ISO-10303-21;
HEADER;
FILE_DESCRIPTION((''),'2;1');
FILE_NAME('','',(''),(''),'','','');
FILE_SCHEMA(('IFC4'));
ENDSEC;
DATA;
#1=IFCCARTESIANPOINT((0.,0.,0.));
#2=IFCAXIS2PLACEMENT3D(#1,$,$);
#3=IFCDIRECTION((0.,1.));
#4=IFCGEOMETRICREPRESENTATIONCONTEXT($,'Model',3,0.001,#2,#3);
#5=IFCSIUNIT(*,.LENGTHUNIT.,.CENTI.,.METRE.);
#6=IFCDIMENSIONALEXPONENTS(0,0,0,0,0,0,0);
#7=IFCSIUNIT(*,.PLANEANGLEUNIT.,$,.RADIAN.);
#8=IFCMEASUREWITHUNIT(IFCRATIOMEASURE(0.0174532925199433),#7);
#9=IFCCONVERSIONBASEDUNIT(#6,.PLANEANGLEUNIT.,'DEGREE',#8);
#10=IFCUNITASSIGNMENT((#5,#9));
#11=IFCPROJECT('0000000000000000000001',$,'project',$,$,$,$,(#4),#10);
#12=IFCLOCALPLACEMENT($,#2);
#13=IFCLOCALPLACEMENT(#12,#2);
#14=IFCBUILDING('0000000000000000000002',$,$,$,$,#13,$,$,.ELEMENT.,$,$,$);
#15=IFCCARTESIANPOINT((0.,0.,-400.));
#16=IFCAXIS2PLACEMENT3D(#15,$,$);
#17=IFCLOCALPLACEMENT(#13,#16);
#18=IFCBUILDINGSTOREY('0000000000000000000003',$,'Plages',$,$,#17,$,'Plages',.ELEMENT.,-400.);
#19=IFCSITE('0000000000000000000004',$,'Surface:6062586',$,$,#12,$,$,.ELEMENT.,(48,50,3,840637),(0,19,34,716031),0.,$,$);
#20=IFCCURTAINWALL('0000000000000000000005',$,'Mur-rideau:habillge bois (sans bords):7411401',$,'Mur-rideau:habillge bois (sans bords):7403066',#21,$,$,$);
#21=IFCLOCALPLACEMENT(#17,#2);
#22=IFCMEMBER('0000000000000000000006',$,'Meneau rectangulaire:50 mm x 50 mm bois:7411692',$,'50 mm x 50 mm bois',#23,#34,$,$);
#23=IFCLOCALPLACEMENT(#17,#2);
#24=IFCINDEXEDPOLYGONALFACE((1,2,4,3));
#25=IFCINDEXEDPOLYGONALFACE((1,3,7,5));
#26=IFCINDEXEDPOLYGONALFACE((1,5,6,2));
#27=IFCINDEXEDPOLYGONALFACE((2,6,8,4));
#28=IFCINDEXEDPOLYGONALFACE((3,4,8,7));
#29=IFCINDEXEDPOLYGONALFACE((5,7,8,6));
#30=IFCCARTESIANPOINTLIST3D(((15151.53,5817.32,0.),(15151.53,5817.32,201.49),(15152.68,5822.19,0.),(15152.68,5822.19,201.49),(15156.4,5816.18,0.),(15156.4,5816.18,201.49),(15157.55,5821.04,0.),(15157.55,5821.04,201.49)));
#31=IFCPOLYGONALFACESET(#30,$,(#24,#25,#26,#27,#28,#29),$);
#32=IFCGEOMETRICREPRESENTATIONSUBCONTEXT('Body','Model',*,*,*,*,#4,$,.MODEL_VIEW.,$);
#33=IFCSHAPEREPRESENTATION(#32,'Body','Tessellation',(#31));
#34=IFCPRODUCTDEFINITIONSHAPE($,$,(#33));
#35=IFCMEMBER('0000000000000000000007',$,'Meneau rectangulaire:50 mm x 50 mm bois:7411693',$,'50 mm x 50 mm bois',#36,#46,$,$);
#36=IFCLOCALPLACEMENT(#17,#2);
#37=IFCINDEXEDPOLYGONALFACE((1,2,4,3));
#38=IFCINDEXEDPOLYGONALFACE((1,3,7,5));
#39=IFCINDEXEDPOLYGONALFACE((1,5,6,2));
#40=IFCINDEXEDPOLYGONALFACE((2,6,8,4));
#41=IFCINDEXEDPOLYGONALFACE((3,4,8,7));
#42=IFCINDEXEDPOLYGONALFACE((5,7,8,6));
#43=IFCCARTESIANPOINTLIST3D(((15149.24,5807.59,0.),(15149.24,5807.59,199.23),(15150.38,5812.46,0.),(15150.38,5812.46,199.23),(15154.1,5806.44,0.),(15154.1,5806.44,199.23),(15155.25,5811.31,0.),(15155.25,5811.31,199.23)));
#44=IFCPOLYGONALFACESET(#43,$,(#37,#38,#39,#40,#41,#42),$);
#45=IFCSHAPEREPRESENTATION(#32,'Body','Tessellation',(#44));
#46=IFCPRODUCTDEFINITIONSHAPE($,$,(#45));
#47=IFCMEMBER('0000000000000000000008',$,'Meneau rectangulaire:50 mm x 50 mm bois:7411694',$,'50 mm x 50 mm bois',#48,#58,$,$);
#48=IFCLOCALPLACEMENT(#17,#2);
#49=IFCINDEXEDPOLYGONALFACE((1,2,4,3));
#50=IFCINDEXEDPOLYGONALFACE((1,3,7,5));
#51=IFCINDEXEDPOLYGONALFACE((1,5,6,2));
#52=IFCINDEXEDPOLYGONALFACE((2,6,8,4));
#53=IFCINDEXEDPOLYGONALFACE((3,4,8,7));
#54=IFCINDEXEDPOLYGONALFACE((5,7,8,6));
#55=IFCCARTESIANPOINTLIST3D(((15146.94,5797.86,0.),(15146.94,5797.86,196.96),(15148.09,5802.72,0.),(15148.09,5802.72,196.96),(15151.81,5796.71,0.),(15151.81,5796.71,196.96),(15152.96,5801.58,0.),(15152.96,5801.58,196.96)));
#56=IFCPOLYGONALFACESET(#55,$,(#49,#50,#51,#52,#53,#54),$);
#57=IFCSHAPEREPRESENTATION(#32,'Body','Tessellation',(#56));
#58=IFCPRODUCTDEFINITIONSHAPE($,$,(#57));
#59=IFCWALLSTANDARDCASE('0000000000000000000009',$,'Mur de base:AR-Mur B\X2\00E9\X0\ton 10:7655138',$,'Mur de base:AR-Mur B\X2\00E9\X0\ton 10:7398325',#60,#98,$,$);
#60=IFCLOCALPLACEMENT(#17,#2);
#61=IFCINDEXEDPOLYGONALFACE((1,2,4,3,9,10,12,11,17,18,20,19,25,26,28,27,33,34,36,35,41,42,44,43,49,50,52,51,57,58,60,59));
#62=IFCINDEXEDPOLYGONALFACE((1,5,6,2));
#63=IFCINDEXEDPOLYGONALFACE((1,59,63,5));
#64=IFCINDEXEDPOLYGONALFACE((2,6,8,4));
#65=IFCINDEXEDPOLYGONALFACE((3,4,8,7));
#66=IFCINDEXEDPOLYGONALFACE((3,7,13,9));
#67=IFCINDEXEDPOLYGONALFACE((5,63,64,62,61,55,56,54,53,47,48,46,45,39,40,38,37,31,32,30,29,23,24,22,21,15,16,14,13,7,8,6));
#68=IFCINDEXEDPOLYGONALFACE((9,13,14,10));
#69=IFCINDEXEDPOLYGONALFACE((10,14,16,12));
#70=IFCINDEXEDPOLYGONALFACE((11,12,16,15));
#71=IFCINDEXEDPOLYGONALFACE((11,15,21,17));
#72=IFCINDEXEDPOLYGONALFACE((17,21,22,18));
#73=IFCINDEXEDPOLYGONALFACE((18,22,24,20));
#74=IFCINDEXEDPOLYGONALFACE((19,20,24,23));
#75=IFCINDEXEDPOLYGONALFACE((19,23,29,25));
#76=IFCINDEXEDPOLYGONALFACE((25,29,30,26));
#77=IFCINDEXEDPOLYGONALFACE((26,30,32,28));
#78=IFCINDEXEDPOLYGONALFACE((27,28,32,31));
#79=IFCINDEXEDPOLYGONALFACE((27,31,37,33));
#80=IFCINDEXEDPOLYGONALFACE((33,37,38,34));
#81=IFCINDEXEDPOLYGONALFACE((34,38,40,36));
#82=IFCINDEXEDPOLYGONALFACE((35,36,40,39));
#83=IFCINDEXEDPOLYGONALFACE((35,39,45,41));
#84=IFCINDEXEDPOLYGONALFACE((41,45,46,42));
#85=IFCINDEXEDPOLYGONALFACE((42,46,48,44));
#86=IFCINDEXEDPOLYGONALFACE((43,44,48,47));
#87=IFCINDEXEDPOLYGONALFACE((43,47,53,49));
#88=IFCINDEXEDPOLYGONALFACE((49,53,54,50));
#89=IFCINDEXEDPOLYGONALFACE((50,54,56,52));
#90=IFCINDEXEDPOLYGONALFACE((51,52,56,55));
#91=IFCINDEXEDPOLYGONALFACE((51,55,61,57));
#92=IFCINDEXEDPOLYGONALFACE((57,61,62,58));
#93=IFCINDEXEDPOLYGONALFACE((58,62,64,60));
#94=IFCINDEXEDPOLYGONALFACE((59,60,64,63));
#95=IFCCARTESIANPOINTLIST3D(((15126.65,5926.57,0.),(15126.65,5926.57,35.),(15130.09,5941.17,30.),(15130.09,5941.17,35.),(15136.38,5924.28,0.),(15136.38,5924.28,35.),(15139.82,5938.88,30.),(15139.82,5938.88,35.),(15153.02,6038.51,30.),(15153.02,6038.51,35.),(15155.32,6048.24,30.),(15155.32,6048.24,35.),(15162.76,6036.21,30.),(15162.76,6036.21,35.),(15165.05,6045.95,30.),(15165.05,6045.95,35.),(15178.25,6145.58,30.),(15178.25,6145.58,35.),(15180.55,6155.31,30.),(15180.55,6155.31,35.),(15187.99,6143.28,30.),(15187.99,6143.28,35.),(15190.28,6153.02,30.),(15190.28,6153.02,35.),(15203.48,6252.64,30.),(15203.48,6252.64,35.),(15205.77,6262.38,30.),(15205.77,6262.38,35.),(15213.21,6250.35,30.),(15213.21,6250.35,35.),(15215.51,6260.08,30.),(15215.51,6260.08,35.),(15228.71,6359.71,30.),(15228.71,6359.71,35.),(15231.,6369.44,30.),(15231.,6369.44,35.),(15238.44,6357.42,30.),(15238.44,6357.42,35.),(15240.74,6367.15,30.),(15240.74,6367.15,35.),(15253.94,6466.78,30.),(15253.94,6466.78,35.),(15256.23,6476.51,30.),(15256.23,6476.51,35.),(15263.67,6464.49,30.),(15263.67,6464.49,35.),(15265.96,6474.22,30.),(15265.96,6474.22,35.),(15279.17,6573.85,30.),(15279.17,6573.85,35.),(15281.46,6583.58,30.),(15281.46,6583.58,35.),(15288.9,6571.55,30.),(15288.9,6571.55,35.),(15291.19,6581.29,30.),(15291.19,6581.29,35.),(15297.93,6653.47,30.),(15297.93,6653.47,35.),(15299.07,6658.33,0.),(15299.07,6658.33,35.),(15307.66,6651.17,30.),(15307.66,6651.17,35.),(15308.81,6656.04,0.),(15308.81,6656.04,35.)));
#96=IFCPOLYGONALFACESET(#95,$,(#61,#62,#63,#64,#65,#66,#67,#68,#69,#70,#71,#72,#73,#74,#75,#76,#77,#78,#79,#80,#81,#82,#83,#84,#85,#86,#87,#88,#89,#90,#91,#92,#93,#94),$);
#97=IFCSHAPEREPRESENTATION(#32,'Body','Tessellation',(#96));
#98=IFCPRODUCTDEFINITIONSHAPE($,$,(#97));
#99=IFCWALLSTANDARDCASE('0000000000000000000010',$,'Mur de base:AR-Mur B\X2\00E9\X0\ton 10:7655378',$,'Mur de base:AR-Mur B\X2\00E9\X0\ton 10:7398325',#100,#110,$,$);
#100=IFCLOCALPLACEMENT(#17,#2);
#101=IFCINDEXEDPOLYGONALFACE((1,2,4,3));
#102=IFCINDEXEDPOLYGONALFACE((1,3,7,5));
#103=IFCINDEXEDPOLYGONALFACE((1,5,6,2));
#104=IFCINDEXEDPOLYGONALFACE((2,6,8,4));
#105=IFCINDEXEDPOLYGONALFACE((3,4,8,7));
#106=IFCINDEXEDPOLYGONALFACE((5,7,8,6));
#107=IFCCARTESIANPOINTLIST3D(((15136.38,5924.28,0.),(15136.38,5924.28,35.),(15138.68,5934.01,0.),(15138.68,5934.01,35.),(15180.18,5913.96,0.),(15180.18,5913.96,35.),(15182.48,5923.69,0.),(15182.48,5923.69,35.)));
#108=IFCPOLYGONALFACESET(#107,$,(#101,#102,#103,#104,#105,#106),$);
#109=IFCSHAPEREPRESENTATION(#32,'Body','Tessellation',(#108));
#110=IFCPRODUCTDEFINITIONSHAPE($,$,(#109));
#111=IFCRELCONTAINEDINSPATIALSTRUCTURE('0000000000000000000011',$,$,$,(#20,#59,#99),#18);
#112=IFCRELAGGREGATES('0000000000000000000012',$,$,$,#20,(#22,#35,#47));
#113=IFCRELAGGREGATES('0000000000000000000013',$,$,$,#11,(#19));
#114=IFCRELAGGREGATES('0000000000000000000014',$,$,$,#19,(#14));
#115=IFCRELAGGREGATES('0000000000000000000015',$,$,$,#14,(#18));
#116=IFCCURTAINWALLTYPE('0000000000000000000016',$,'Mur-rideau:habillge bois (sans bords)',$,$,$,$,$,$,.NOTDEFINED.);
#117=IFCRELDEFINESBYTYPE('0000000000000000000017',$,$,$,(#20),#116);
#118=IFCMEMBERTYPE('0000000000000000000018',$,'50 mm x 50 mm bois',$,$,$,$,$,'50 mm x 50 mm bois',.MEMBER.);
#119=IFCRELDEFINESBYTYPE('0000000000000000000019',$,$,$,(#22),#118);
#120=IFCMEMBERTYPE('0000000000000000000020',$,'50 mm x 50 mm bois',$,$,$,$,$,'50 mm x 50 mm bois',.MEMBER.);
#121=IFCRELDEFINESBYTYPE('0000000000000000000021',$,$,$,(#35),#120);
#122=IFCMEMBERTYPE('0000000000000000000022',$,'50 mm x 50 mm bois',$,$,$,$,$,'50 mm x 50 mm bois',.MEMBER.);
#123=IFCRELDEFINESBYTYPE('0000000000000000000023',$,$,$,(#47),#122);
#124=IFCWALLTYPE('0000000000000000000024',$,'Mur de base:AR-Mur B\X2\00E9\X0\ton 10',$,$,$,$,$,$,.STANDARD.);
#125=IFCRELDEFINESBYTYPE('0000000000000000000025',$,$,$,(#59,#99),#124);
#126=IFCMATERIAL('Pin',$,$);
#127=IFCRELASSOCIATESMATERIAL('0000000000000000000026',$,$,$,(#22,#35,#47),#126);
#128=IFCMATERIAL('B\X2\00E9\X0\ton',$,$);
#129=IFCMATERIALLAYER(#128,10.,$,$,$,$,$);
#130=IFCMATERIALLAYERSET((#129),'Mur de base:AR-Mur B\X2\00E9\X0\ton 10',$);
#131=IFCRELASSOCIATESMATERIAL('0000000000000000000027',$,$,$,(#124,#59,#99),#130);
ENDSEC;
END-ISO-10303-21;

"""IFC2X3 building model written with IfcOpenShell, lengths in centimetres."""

from ifc_helpers import new_model, entity, si_unit, converted_unit, direction, frame, frame_2d, origin, origin_2d_with_axis, place, context, subcontext, project, spatial, rectangle, extrude, source, transform, mapped, material, layer, layer_set, layer_usage, type_object, type_shapes, element, aggregate, save


model = new_model("IFC2X3")

# Units and contexts
model_context = context("Model", 3, precision=0.001, world=origin(), true_north=direction((0.0, 1.0)))
body_context = subcontext(model_context, "Body", "Model", "MODEL_VIEW")
ifc_project = project(units=[si_unit("LENGTHUNIT", "METRE", prefix="CENTI"), converted_unit("PLANEANGLEUNIT", "DEGREE", entity("IfcRatioMeasure", 0.0174532925199433), si_unit("PLANEANGLEUNIT", "RADIAN"), dimensions=[0, 0, 0, 0, 0, 0, 0])], contexts=[model_context])

# Site, building, storey
site_placement = place(None, origin())
site = spatial("IfcSite", under=ifc_project, at=site_placement, Name="Surface:6062586", CompositionType="ELEMENT", RefLatitude=(48, 50, 3, 840637), RefLongitude=(0, 19, 34, 716031), RefElevation=0.0)
building_placement = place(site_placement, origin())
building = spatial("IfcBuilding", under=site, at=building_placement, CompositionType="ELEMENT")
storey_placement = place(building_placement, frame((0.0, 0.0, -400.0)))
storey = spatial("IfcBuildingStorey", under=building, at=storey_placement, Name="Plages", LongName="Plages", CompositionType="ELEMENT", Elevation=-400.0)

# Curtain wall, members
curtain_wall_type = type_object("IfcCurtainWallType", Name="Mur-rideau:habillge bois (sans bords)", PredefinedType="NOTDEFINED")
curtain_wall_placement = place(storey_placement, frame((0.0, 0.0, 400.0)))
curtain_wall = element("IfcCurtainWall", 1, at=curtain_wall_placement, inside=storey, type_object=curtain_wall_type, Name="Mur-rideau:habillge bois (sans bords):7411401", ObjectType="Mur-rideau:habillge bois (sans bords):7403066")
ifc_material_1 = material(Name="Pin")
member_type_1 = type_object("IfcMemberType", Name="50 mm x 50 mm bois", ElementType="50 mm x 50 mm bois", PredefinedType="MEMBER")
shared_shape_1 = source(origin(), body_context, "Body", "SweptSolid", [
    extrude(rectangle(XDim=5.0, YDim=5.0, at=origin_2d_with_axis()), frame((0.0, 0.0, -201.49), z_axis=(0.0, 0.0, 1.0), x_axis=(0.0, -1.0, 0.0)), (0.0, 0.0, 1.0), 201.49),
])
type_shapes(member_type_1, [shared_shape_1])
member_1_placement = place(storey_placement, frame((15154.54, 5819.18, 0.0), z_axis=(0.0, 0.0, -1.0), x_axis=(-0.229349, -0.973344, 0.0)))
member_1 = element("IfcMember", 2, at=member_1_placement, type_object=member_type_1, material=ifc_material_1, Name="Meneau rectangulaire:50 mm x 50 mm bois:7411692", ObjectType="50 mm x 50 mm bois", context=body_context, shape_type="MappedRepresentation", body=[
    mapped(shared_shape_1, transform((0.0, 0.0, 0.0), scale=1.0)),
])
member_type_2 = type_object("IfcMemberType", Name="50 mm x 50 mm bois", ElementType="50 mm x 50 mm bois", PredefinedType="MEMBER")
shared_shape_2 = source(origin(), body_context, "Body", "SweptSolid", [
    extrude(rectangle(XDim=5.0, YDim=5.0, at=origin_2d_with_axis()), frame((0.0, 0.0, -199.23), z_axis=(0.0, 0.0, 1.0), x_axis=(0.0, -1.0, 0.0)), (0.0, 0.0, 1.0), 199.23),
])
type_shapes(member_type_2, [shared_shape_2])
member_2_placement = place(storey_placement, frame((15152.24, 5809.45, 0.0), z_axis=(0.0, 0.0, -1.0), x_axis=(-0.229349, -0.973344, 0.0)))
member_2 = element("IfcMember", 3, at=member_2_placement, type_object=member_type_2, material=ifc_material_1, Name="Meneau rectangulaire:50 mm x 50 mm bois:7411693", ObjectType="50 mm x 50 mm bois", context=body_context, shape_type="MappedRepresentation", body=[
    mapped(shared_shape_2, transform((0.0, 0.0, 0.0), scale=1.0)),
])
member_type_3 = type_object("IfcMemberType", Name="50 mm x 50 mm bois", ElementType="50 mm x 50 mm bois", PredefinedType="MEMBER")
shared_shape_3 = source(origin(), body_context, "Body", "SweptSolid", [
    extrude(rectangle(XDim=5.0, YDim=5.0, at=origin_2d_with_axis()), frame((0.0, 0.0, -196.96), z_axis=(0.0, 0.0, 1.0), x_axis=(0.0, -1.0, 0.0)), (0.0, 0.0, 1.0), 196.96),
])
type_shapes(member_type_3, [shared_shape_3])
member_3_placement = place(storey_placement, frame((15149.95, 5799.72, 0.0), z_axis=(0.0, 0.0, -1.0), x_axis=(-0.229349, -0.973344, 0.0)))
member_3 = element("IfcMember", 4, at=member_3_placement, type_object=member_type_3, material=ifc_material_1, Name="Meneau rectangulaire:50 mm x 50 mm bois:7411694", ObjectType="50 mm x 50 mm bois", context=body_context, shape_type="MappedRepresentation", body=[
    mapped(shared_shape_3, transform((0.0, 0.0, 0.0), scale=1.0)),
])
aggregate(curtain_wall, [member_1, member_2, member_3])

# Wall, openings
ifc_material_2 = material(Name="Béton")
ifc_layer = layer(ifc_material_2, 10.0)
ifc_layer_set = layer_set([ifc_layer], Name="Mur de base:AR-Mur Béton 10")
ifc_layer_usage_1 = layer_usage(ifc_layer_set, "AXIS2", "NEGATIVE", 5.0)
wall_type = type_object("IfcWallType", Name="Mur de base:AR-Mur Béton 10", PredefinedType="STANDARD", material=ifc_layer_set)
wall_1_placement = place(storey_placement, frame((15131.52, 5925.43, 0.0), z_axis=(0.0, 0.0, 1.0), x_axis=(0.229349, 0.973344, 0.0)))
wall_1 = element("IfcWallStandardCase", 5, at=wall_1_placement, inside=storey, type_object=wall_type, material=ifc_layer_usage_1, Name="Mur de base:AR-Mur Béton 10:7655138", ObjectType="Mur de base:AR-Mur Béton 10:7398325", context=body_context, shape_type="SweptSolid", body=[
    extrude(rectangle(XDim=751.8, YDim=10.0, at=frame_2d((375.9, 0.0), x_axis=(-1.0, 0.0))), origin(), (0.0, 0.0, 1.0), 35.0),
])
opening_1_placement = place(wall_1_placement, origin())
element("IfcOpeningElement", 6, at=opening_1_placement, cuts=wall_1, ObjectType="Opening", context=body_context, shape_type="SweptSolid", body=[
    extrude(rectangle(XDim=5.0, YDim=71.8, at=frame_2d((0.0, 0.0), x_axis=(0.0, 1.0))), frame((710.9, 5.0, 32.5), z_axis=(0.0, -1.0, 0.0), x_axis=(-1.0, 0.0, 0.0)), (0.0, 0.0, 1.0), 10.0),
])
opening_2_placement = place(wall_1_placement, origin())
element("IfcOpeningElement", 7, at=opening_2_placement, cuts=wall_1, ObjectType="Opening", context=body_context, shape_type="SweptSolid", body=[
    extrude(rectangle(XDim=5.0, YDim=100.0, at=frame_2d((0.0, 0.0), x_axis=(0.0, 1.0))), frame((615.0, 5.0, 32.5), z_axis=(0.0, -1.0, 0.0), x_axis=(-1.0, 0.0, 0.0)), (0.0, 0.0, 1.0), 10.0),
])
opening_3_placement = place(wall_1_placement, origin())
element("IfcOpeningElement", 8, at=opening_3_placement, cuts=wall_1, ObjectType="Opening", context=body_context, shape_type="SweptSolid", body=[
    extrude(rectangle(XDim=5.0, YDim=100.0, at=frame_2d((0.0, 0.0), x_axis=(0.0, 1.0))), frame((505.0, 5.0, 32.5), z_axis=(0.0, -1.0, 0.0), x_axis=(-1.0, 0.0, 0.0)), (0.0, 0.0, 1.0), 10.0),
])
opening_4_placement = place(wall_1_placement, origin())
element("IfcOpeningElement", 9, at=opening_4_placement, cuts=wall_1, ObjectType="Opening", context=body_context, shape_type="SweptSolid", body=[
    extrude(rectangle(XDim=5.0, YDim=100.0, at=frame_2d((0.0, 0.0), x_axis=(0.0, 1.0))), frame((395.0, 5.0, 32.5), z_axis=(0.0, -1.0, 0.0), x_axis=(-1.0, 0.0, 0.0)), (0.0, 0.0, 1.0), 10.0),
])
opening_5_placement = place(wall_1_placement, origin())
element("IfcOpeningElement", 10, at=opening_5_placement, cuts=wall_1, ObjectType="Opening", context=body_context, shape_type="SweptSolid", body=[
    extrude(rectangle(XDim=5.0, YDim=100.0, at=frame_2d((0.0, 0.0), x_axis=(0.0, 1.0))), frame((285.0, 5.0, 32.5), z_axis=(0.0, -1.0, 0.0), x_axis=(-1.0, 0.0, 0.0)), (0.0, 0.0, 1.0), 10.0),
])
opening_6_placement = place(wall_1_placement, origin())
element("IfcOpeningElement", 11, at=opening_6_placement, cuts=wall_1, ObjectType="Opening", context=body_context, shape_type="SweptSolid", body=[
    extrude(rectangle(XDim=5.0, YDim=100.0, at=frame_2d((0.0, 0.0), x_axis=(0.0, 1.0))), frame((175.0, 5.0, 32.5), z_axis=(0.0, -1.0, 0.0), x_axis=(-1.0, 0.0, 0.0)), (0.0, 0.0, 1.0), 10.0),
])
opening_7_placement = place(wall_1_placement, origin())
element("IfcOpeningElement", 12, at=opening_7_placement, cuts=wall_1, ObjectType="Opening", context=body_context, shape_type="SweptSolid", body=[
    extrude(rectangle(XDim=5.0, YDim=100.0, at=frame_2d((0.0, 0.0), x_axis=(0.0, 1.0))), frame((65.0, 5.0, 32.5), z_axis=(0.0, -1.0, 0.0), x_axis=(-1.0, 0.0, 0.0)), (0.0, 0.0, 1.0), 10.0),
])

# Wall
ifc_layer_usage_2 = layer_usage(ifc_layer_set, "AXIS2", "NEGATIVE", 5.0)
wall_2_placement = place(storey_placement, frame((15181.33, 5918.83, 0.0), z_axis=(0.0, 0.0, 1.0), x_axis=(-0.973344, 0.229349, 0.0)))
element("IfcWallStandardCase", 13, at=wall_2_placement, inside=storey, type_object=wall_type, material=ifc_layer_usage_2, Name="Mur de base:AR-Mur Béton 10:7655378", ObjectType="Mur de base:AR-Mur Béton 10:7398325", context=body_context, shape_type="SweptSolid", body=[
    extrude(rectangle(XDim=45.0, YDim=10.0, at=frame_2d((22.5, 0.0), x_axis=(-1.0, 0.0))), origin(), (0.0, 0.0, 1.0), 35.0),
])

save(model, "model.ifc")
